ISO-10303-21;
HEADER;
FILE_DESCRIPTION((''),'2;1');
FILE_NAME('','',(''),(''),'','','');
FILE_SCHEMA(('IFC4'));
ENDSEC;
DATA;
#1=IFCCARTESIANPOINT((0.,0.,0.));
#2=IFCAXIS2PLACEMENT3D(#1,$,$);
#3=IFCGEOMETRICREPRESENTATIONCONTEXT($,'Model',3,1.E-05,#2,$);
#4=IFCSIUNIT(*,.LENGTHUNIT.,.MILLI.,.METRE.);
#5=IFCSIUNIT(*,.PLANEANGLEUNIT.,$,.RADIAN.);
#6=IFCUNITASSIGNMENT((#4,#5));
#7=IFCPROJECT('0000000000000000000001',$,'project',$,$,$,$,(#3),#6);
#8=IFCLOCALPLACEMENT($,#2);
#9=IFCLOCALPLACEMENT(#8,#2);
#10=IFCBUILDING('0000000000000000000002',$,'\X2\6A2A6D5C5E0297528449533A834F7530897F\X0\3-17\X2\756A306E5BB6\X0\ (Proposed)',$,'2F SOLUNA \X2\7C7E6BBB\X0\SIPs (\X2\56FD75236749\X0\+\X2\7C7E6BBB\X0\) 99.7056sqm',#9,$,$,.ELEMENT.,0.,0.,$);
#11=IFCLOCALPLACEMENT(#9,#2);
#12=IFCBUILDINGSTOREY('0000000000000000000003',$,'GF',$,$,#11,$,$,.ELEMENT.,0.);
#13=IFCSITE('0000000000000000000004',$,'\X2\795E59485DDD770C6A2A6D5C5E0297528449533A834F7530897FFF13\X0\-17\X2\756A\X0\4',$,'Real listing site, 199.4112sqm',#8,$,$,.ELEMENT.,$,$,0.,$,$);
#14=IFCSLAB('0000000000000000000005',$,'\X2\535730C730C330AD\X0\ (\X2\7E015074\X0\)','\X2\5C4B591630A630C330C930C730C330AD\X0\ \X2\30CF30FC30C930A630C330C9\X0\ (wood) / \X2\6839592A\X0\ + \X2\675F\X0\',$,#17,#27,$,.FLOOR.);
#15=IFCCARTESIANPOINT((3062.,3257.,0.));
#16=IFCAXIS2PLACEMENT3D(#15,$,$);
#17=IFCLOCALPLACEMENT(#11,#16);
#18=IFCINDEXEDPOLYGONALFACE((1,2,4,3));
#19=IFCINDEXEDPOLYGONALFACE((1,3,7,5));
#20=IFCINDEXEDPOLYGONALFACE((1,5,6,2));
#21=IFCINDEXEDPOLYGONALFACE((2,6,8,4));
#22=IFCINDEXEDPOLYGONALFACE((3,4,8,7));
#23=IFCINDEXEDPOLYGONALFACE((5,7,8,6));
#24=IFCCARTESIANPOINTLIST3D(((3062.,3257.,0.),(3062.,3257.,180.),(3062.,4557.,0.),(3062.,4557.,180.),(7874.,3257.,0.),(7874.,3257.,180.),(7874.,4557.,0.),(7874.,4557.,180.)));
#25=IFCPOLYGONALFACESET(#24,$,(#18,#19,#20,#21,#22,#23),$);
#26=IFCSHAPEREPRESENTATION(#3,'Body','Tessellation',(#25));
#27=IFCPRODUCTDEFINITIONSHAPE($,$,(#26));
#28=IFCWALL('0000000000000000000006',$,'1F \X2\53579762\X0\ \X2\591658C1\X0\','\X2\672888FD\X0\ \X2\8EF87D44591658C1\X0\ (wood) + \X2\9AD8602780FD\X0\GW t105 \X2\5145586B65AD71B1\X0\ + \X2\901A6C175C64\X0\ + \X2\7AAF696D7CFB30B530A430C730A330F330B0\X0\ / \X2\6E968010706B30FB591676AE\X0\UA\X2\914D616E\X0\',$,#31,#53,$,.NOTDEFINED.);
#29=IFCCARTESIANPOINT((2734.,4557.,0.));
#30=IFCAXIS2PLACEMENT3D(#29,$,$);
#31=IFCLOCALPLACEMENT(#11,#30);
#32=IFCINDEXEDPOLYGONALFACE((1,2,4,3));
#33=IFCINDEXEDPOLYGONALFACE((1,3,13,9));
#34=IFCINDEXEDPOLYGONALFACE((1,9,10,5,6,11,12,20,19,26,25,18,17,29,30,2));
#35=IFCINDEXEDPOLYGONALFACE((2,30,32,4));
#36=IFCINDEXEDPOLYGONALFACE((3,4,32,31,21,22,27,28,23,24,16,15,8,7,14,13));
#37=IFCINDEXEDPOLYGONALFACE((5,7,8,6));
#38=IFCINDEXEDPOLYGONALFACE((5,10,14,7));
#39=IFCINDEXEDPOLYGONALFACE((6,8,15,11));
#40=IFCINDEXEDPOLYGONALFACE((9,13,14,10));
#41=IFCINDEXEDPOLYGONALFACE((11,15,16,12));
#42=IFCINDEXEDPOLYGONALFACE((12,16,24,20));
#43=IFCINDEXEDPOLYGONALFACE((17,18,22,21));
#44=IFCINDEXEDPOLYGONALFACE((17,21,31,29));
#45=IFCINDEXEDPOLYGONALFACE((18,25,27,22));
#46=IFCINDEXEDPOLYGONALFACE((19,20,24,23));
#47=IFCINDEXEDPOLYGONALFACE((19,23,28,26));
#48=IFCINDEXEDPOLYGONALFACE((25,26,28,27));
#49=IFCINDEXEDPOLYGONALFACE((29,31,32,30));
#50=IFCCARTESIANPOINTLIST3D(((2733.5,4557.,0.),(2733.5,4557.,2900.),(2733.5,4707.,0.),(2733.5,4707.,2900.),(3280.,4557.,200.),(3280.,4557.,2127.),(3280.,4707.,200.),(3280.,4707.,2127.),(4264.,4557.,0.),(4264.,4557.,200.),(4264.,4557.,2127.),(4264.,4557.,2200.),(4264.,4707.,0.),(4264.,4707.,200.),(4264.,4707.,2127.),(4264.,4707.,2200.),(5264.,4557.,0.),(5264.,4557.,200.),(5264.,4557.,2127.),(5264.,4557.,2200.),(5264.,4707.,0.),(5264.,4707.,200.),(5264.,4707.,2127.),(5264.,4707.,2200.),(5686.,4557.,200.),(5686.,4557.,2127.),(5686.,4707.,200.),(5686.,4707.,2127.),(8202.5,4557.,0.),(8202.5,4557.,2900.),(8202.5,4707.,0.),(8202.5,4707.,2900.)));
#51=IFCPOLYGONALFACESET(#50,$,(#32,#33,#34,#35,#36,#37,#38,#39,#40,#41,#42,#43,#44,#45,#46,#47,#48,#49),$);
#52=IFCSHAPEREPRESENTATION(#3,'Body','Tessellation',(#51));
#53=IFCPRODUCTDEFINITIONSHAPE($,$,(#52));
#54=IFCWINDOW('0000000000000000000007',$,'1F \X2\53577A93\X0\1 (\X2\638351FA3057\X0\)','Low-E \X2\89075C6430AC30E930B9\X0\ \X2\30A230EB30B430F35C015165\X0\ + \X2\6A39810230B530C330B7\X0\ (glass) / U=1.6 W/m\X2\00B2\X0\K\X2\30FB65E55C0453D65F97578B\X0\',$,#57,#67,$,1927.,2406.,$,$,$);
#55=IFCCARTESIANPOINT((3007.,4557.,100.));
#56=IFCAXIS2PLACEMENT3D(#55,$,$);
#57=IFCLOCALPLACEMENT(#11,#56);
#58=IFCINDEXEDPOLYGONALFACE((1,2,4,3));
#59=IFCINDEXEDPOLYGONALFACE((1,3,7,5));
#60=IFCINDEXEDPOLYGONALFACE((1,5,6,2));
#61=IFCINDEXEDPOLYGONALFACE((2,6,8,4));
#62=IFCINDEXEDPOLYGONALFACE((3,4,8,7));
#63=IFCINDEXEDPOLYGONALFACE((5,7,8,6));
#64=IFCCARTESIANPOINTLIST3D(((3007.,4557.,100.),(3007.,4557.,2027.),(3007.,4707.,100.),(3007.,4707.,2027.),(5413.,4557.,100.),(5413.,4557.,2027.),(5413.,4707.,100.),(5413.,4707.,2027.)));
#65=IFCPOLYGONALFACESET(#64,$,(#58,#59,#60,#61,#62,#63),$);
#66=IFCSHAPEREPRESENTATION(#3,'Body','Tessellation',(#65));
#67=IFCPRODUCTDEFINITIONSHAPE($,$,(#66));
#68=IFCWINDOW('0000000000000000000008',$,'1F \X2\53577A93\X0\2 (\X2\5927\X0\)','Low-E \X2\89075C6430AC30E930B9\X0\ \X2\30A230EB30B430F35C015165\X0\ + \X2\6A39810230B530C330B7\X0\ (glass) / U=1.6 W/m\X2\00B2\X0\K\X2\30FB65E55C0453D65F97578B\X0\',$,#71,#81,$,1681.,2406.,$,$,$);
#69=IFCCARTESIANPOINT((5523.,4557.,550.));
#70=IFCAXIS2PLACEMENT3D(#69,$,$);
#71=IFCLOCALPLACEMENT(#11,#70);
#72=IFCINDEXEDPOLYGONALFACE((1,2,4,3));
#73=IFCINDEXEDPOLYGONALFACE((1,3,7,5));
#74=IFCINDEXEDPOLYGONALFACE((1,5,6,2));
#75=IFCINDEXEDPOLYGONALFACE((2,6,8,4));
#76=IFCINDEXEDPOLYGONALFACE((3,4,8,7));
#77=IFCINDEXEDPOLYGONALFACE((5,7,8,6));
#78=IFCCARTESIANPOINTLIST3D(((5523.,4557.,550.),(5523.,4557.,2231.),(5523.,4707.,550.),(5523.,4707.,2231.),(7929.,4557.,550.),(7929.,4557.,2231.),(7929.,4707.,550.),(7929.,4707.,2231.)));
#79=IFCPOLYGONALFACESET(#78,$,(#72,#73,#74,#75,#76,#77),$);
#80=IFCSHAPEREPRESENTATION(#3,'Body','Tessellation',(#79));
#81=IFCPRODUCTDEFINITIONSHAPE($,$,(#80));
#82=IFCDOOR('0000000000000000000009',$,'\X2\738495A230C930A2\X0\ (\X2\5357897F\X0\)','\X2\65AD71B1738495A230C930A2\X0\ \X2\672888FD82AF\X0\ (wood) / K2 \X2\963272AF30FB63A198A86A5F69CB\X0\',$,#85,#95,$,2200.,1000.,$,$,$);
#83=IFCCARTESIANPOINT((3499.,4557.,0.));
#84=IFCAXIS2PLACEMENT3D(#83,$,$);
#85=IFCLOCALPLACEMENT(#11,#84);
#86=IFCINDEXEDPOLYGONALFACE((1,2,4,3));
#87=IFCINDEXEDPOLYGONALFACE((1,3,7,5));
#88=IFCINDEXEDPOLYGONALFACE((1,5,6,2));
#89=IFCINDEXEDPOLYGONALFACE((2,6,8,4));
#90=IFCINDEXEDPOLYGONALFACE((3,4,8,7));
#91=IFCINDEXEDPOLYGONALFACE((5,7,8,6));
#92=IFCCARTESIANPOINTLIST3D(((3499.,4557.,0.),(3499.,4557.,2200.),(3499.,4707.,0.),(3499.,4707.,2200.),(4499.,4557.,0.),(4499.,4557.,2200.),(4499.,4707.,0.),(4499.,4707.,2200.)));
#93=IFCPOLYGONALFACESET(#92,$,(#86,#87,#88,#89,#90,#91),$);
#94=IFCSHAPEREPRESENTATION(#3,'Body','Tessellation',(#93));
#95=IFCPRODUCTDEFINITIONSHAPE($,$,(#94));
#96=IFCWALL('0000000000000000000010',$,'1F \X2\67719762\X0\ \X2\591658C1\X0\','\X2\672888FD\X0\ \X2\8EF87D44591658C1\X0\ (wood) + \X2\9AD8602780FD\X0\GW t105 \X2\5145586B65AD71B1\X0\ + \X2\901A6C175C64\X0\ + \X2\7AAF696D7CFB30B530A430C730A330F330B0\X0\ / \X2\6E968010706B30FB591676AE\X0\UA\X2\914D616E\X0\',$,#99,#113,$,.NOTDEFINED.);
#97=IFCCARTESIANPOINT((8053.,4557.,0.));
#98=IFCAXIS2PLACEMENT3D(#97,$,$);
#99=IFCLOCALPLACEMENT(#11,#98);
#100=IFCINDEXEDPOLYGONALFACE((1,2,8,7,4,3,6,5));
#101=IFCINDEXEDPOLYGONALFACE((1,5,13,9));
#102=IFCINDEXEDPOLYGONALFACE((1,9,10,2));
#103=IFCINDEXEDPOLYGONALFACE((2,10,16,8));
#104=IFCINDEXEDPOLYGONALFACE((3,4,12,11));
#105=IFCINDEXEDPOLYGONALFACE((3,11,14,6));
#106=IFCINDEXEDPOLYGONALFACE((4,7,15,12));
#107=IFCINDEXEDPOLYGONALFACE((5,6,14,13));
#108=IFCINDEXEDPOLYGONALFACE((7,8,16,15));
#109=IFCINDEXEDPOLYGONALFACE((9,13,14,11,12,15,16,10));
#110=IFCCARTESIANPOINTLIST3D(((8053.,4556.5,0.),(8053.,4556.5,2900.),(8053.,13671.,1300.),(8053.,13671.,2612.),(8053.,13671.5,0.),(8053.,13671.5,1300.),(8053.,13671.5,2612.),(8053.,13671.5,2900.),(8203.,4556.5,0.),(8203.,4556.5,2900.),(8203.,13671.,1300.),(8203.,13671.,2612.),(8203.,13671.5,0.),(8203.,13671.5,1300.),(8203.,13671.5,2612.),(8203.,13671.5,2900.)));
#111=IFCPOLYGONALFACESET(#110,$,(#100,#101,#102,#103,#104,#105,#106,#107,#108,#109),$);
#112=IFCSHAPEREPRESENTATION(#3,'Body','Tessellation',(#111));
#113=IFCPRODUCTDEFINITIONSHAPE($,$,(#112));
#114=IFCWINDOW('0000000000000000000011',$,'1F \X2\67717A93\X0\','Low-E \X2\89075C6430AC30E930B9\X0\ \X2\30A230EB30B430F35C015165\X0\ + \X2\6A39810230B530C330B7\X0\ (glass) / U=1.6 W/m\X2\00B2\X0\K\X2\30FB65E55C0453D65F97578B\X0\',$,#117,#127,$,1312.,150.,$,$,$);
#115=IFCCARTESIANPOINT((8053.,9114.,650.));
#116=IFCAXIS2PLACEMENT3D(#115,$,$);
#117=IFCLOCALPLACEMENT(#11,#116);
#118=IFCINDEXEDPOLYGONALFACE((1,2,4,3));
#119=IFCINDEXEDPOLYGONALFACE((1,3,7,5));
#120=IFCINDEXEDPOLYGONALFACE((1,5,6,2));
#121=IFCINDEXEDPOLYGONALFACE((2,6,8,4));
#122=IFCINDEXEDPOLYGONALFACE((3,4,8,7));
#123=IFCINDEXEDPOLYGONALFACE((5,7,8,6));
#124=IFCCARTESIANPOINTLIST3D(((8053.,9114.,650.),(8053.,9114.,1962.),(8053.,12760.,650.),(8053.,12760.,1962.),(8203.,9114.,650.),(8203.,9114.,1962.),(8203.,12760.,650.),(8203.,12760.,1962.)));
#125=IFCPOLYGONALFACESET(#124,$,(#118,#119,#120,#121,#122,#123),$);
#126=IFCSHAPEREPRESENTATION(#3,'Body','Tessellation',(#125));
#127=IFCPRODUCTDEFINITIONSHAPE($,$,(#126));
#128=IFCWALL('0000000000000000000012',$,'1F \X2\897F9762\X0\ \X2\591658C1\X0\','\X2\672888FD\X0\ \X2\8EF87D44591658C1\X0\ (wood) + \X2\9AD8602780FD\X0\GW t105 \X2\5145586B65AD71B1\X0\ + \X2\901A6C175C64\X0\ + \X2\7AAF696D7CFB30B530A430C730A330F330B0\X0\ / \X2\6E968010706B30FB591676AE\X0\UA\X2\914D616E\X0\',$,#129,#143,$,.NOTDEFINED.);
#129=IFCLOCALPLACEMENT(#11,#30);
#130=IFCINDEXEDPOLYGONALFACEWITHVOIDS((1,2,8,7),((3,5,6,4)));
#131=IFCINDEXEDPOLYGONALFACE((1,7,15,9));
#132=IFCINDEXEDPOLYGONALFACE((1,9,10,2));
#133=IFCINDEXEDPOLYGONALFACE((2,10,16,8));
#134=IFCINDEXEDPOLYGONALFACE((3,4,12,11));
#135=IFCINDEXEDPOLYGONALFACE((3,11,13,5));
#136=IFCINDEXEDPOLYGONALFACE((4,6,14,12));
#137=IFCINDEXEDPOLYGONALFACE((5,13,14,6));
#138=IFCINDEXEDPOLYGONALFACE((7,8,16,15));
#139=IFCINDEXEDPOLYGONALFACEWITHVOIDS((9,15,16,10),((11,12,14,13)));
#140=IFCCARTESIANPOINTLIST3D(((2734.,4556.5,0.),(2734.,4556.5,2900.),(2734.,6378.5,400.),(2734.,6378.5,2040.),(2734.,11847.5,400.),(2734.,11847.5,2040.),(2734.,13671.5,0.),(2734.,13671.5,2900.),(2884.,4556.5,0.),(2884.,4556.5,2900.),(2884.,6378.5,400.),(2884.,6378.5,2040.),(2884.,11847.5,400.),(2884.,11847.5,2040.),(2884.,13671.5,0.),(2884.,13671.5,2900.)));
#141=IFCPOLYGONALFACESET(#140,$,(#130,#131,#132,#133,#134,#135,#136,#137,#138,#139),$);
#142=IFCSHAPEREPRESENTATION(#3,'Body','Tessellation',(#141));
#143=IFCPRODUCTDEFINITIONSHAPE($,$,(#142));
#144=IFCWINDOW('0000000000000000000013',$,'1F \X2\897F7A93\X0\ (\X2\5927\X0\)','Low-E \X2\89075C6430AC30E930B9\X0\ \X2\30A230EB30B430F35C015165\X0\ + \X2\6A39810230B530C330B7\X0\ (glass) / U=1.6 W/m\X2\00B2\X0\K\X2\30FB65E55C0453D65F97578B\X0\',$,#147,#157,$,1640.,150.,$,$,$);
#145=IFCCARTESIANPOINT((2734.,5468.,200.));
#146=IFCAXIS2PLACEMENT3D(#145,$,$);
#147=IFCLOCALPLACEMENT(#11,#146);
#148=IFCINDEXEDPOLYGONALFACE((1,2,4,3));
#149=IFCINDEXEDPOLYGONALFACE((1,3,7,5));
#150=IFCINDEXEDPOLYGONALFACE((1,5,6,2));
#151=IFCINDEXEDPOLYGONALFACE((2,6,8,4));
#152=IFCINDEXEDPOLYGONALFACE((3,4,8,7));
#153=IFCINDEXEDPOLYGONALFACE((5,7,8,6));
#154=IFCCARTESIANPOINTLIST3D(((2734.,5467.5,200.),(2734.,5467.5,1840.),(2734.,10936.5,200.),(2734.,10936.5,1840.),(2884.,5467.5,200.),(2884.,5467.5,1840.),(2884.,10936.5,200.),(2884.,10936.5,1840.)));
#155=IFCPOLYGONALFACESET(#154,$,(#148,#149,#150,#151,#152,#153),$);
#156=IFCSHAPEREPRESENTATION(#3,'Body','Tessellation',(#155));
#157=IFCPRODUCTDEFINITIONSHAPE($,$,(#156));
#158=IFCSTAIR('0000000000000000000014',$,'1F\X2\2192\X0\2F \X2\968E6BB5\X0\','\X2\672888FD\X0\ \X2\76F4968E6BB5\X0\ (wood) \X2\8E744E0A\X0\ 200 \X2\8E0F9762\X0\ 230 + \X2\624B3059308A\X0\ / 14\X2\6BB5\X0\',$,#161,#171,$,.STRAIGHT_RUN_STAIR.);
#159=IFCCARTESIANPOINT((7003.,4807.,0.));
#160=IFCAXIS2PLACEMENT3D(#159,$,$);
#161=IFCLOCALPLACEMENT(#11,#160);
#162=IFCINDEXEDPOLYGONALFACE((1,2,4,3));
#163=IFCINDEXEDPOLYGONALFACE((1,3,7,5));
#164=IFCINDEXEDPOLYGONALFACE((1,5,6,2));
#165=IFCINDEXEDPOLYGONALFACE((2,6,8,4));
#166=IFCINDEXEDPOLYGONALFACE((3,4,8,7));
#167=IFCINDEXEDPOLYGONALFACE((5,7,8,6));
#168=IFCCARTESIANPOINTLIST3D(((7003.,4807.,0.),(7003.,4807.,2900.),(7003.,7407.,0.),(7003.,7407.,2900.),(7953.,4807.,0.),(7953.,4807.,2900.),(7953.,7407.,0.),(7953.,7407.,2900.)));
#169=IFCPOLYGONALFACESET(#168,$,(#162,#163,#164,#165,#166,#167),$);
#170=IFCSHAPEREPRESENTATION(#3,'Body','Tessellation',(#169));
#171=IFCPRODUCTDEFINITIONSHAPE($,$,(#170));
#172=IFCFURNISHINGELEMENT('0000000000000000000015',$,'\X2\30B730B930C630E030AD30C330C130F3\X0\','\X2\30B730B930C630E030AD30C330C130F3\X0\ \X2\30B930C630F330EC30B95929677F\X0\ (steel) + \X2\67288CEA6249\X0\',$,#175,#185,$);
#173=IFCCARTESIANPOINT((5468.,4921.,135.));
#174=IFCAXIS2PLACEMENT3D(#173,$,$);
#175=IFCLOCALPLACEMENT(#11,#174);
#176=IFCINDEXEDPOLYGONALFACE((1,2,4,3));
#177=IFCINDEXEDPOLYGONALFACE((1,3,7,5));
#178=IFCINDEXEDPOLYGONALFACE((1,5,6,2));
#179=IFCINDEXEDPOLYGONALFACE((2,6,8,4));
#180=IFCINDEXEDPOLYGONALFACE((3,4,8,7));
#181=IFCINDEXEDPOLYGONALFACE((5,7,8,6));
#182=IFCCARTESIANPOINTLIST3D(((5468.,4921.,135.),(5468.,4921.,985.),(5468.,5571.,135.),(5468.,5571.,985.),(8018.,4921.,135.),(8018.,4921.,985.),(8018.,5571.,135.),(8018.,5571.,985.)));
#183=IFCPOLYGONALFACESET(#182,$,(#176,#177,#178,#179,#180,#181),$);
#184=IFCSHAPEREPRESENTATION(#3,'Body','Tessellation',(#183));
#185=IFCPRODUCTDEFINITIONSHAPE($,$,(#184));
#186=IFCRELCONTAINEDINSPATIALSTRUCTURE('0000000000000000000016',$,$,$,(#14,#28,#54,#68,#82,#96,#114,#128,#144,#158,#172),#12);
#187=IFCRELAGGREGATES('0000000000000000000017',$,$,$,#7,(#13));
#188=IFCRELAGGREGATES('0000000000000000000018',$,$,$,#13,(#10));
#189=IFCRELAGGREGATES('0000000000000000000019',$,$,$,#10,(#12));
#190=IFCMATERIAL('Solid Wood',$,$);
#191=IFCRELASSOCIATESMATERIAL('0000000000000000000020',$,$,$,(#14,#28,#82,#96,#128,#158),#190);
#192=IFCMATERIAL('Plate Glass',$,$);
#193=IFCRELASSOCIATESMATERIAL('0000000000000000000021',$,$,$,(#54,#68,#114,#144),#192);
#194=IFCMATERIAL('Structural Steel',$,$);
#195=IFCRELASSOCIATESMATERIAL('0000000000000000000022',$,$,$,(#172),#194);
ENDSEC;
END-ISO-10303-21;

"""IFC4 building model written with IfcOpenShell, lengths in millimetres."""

from ifc_helpers import new_model, si_unit, frame, frame_2d, origin, place, context, project, spatial, rectangle, extrude, material, element, fill, save


model = new_model("IFC4")

# Units and contexts
model_context = context("Model", 3, precision=1e-05, world=origin())
ifc_project = project(units=[si_unit("LENGTHUNIT", "METRE", prefix="MILLI"), si_unit("PLANEANGLEUNIT", "RADIAN")], contexts=[model_context])

# Site, building, storey
site_placement = place(None, origin())
site = spatial("IfcSite", under=ifc_project, at=site_placement, Name="神奈川県横浜市青葉区荏田西３-17番4", ObjectType="Real listing site, 199.4112sqm", CompositionType="ELEMENT", RefElevation=0.0)
building_placement = place(site_placement, origin())
building = spatial("IfcBuilding", under=site, at=building_placement, Name="横浜市青葉区荏田西3-17番の家 (Proposed)", ObjectType="2F SOLUNA 籾殻SIPs (国産杉+籾殻) 99.7056sqm", CompositionType="ELEMENT", ElevationOfRefHeight=0.0, ElevationOfTerrain=0.0)
storey_placement = place(building_placement, origin())
storey = spatial("IfcBuildingStorey", under=building, at=storey_placement, Name="GF", CompositionType="ELEMENT", Elevation=0.0)

# Slab
ifc_material_1 = material(Name="Solid Wood")
slab_1_placement = place(storey_placement, frame((3062.0, 3257.0, 0.0)))
element("IfcSlab", 1, at=slab_1_placement, inside=storey, material=ifc_material_1, Name="南デッキ (縁側)", Description="屋外ウッドデッキ ハードウッド (wood) / 根太 + 束", PredefinedType="FLOOR", context=model_context, shape_type="SweptSolid", body=[
    extrude(rectangle(XDim=4812.0, YDim=1300.0, at=frame_2d((2406.0, 650.0))), frame((3062.0, 3257.0, 0.0)), (0.0, 0.0, 1.0), 180.0),
])

# Wall, openings, windows, door
wall_1_placement = place(storey_placement, frame((2734.0, 4557.0, 0.0)))
wall_1 = element("IfcWall", 2, at=wall_1_placement, inside=storey, material=ifc_material_1, Name="1F 南面 外壁", Description="木製 軸組外壁 (wood) + 高性能GW t105 充填断熱 + 通気層 + 窯業系サイディング / 準耐火・外皮UA配慮", PredefinedType="NOTDEFINED", context=model_context, shape_type="SweptSolid", body=[
    extrude(rectangle(XDim=5469.0, YDim=150.0, at=frame_2d((2734.0, 75.0))), frame((2734.0, 4557.0, 0.0)), (0.0, 0.0, 1.0), 2900.0),
])
opening_1_placement = place(storey_placement, frame((3007.0, 4557.0, 100.0)))
opening_1 = element("IfcOpeningElement", 3, at=opening_1_placement, cuts=wall_1, PredefinedType="NOTDEFINED", context=model_context, shape_type="SweptSolid", body=[
    extrude(rectangle(XDim=2406.0, YDim=150.0, at=frame_2d((1203.0, 75.0))), frame((3007.0, 4557.0, 100.0)), (0.0, 0.0, 1.0), 1927.0),
])
opening_2_placement = place(storey_placement, frame((5523.0, 4557.0, 550.0)))
opening_2 = element("IfcOpeningElement", 4, at=opening_2_placement, cuts=wall_1, PredefinedType="NOTDEFINED", context=model_context, shape_type="SweptSolid", body=[
    extrude(rectangle(XDim=2406.0, YDim=150.0, at=frame_2d((1203.0, 75.0))), frame((5523.0, 4557.0, 550.0)), (0.0, 0.0, 1.0), 1681.0),
])
opening_3_placement = place(storey_placement, frame((3499.0, 4557.0, 0.0)))
opening_3 = element("IfcOpeningElement", 5, at=opening_3_placement, cuts=wall_1, PredefinedType="NOTDEFINED", context=model_context, shape_type="SweptSolid", body=[
    extrude(rectangle(XDim=1000.0, YDim=150.0, at=frame_2d((500.0, 75.0))), frame((3499.0, 4557.0, 0.0)), (0.0, 0.0, 1.0), 2200.0),
])
ifc_material_2 = material(Name="Plate Glass")
window_1_placement = place(storey_placement, frame((3007.0, 4557.0, 100.0)))
window_1 = element("IfcWindow", 6, at=window_1_placement, inside=storey, material=ifc_material_2, Name="1F 南窓1 (掃出し)", Description="Low-E 複層ガラス アルゴン封入 + 樹脂サッシ (glass) / U=1.6 W/m²K・日射取得型", OverallHeight=1927.0, OverallWidth=2406.0, context=model_context, shape_type="SweptSolid", body=[
    extrude(rectangle(XDim=2406.0, YDim=150.0, at=frame_2d((1203.0, 75.0))), frame((3007.0, 4557.0, 100.0)), (0.0, 0.0, 1.0), 1927.0),
])
fill(opening_1, window_1)
window_2_placement = place(storey_placement, frame((5523.0, 4557.0, 550.0)))
window_2 = element("IfcWindow", 7, at=window_2_placement, inside=storey, material=ifc_material_2, Name="1F 南窓2 (大)", Description="Low-E 複層ガラス アルゴン封入 + 樹脂サッシ (glass) / U=1.6 W/m²K・日射取得型", OverallHeight=1681.0, OverallWidth=2406.0, context=model_context, shape_type="SweptSolid", body=[
    extrude(rectangle(XDim=2406.0, YDim=150.0, at=frame_2d((1203.0, 75.0))), frame((5523.0, 4557.0, 550.0)), (0.0, 0.0, 1.0), 1681.0),
])
fill(opening_2, window_2)
door_placement = place(storey_placement, frame((3499.0, 4557.0, 0.0)))
door = element("IfcDoor", 8, at=door_placement, inside=storey, material=ifc_material_1, Name="玄関ドア (南西)", Description="断熱玄関ドア 木製芯 (wood) / K2 防犯・採風機構", OverallHeight=2200.0, OverallWidth=1000.0, context=model_context, shape_type="SweptSolid", body=[
    extrude(rectangle(XDim=1000.0, YDim=150.0, at=frame_2d((500.0, 75.0))), frame((3499.0, 4557.0, 0.0)), (0.0, 0.0, 1.0), 2200.0),
])
fill(opening_3, door)

# Walls, openings, windows
wall_2_placement = place(storey_placement, frame((8053.0, 4557.0, 0.0)))
wall_2 = element("IfcWall", 9, at=wall_2_placement, inside=storey, material=ifc_material_1, Name="1F 東面 外壁", Description="木製 軸組外壁 (wood) + 高性能GW t105 充填断熱 + 通気層 + 窯業系サイディング / 準耐火・外皮UA配慮", PredefinedType="NOTDEFINED", context=model_context, shape_type="SweptSolid", body=[
    extrude(rectangle(XDim=150.0, YDim=9115.0, at=frame_2d((75.0, 4557.0))), frame((8053.0, 4557.0, 0.0)), (0.0, 0.0, 1.0), 2900.0),
])
opening_4_placement = place(storey_placement, frame((8053.0, 9114.0, 650.0)))
opening_4 = element("IfcOpeningElement", 10, at=opening_4_placement, cuts=wall_2, PredefinedType="NOTDEFINED", context=model_context, shape_type="SweptSolid", body=[
    extrude(rectangle(XDim=150.0, YDim=3646.0, at=frame_2d((75.0, 1823.0))), frame((8053.0, 9114.0, 650.0)), (0.0, 0.0, 1.0), 1312.0),
])
window_3_placement = place(storey_placement, frame((8053.0, 9114.0, 650.0)))
window_3 = element("IfcWindow", 11, at=window_3_placement, inside=storey, material=ifc_material_2, Name="1F 東窓", Description="Low-E 複層ガラス アルゴン封入 + 樹脂サッシ (glass) / U=1.6 W/m²K・日射取得型", OverallHeight=1312.0, OverallWidth=150.0, context=model_context, shape_type="SweptSolid", body=[
    extrude(rectangle(XDim=150.0, YDim=3646.0, at=frame_2d((75.0, 1823.0))), frame((8053.0, 9114.0, 650.0)), (0.0, 0.0, 1.0), 1312.0),
])
fill(opening_4, window_3)
wall_3_placement = place(storey_placement, frame((2734.0, 4557.0, 0.0)))
wall_3 = element("IfcWall", 12, at=wall_3_placement, inside=storey, material=ifc_material_1, Name="1F 西面 外壁", Description="木製 軸組外壁 (wood) + 高性能GW t105 充填断熱 + 通気層 + 窯業系サイディング / 準耐火・外皮UA配慮", PredefinedType="NOTDEFINED", context=model_context, shape_type="SweptSolid", body=[
    extrude(rectangle(XDim=150.0, YDim=9115.0, at=frame_2d((75.0, 4557.0))), frame((2734.0, 4557.0, 0.0)), (0.0, 0.0, 1.0), 2900.0),
])
opening_5_placement = place(storey_placement, frame((2734.0, 5468.0, 200.0)))
opening_5 = element("IfcOpeningElement", 13, at=opening_5_placement, cuts=wall_3, PredefinedType="NOTDEFINED", context=model_context, shape_type="SweptSolid", body=[
    extrude(rectangle(XDim=150.0, YDim=5469.0, at=frame_2d((75.0, 2734.0))), frame((2734.0, 5468.0, 200.0)), (0.0, 0.0, 1.0), 1640.0),
])
window_4_placement = place(storey_placement, frame((2734.0, 5468.0, 200.0)))
window_4 = element("IfcWindow", 14, at=window_4_placement, inside=storey, material=ifc_material_2, Name="1F 西窓 (大)", Description="Low-E 複層ガラス アルゴン封入 + 樹脂サッシ (glass) / U=1.6 W/m²K・日射取得型", OverallHeight=1640.0, OverallWidth=150.0, context=model_context, shape_type="SweptSolid", body=[
    extrude(rectangle(XDim=150.0, YDim=5469.0, at=frame_2d((75.0, 2734.0))), frame((2734.0, 5468.0, 200.0)), (0.0, 0.0, 1.0), 1640.0),
])
fill(opening_5, window_4)

# Stair
stair_placement = place(storey_placement, frame((7003.0, 4807.0, 0.0)))
element("IfcStair", 15, at=stair_placement, inside=storey, material=ifc_material_1, Name="1F→2F 階段", Description="木製 直階段 (wood) 蹴上 200 踏面 230 + 手すり / 14段", PredefinedType="STRAIGHT_RUN_STAIR", context=model_context, shape_type="SweptSolid", body=[
    extrude(rectangle(XDim=950.0, YDim=2600.0, at=frame_2d((475.0, 1300.0))), frame((7003.0, 4807.0, 0.0)), (0.0, 0.0, 1.0), 2900.0),
])

# Furnishing element
ifc_material_3 = material(Name="Structural Steel")
furnishing_placement = place(storey_placement, frame((5468.0, 4921.0, 135.0)))
element("IfcFurnishingElement", 16, at=furnishing_placement, inside=storey, material=ifc_material_3, Name="システムキッチン", Description="システムキッチン ステンレス天板 (steel) + 木質扉", context=model_context, shape_type="SweptSolid", body=[
    extrude(rectangle(XDim=2550.0, YDim=650.0, at=frame_2d((1275.0, 325.0))), frame((5468.0, 4921.0, 135.0)), (0.0, 0.0, 1.0), 850.0),
])

save(model, "model.ifc")
